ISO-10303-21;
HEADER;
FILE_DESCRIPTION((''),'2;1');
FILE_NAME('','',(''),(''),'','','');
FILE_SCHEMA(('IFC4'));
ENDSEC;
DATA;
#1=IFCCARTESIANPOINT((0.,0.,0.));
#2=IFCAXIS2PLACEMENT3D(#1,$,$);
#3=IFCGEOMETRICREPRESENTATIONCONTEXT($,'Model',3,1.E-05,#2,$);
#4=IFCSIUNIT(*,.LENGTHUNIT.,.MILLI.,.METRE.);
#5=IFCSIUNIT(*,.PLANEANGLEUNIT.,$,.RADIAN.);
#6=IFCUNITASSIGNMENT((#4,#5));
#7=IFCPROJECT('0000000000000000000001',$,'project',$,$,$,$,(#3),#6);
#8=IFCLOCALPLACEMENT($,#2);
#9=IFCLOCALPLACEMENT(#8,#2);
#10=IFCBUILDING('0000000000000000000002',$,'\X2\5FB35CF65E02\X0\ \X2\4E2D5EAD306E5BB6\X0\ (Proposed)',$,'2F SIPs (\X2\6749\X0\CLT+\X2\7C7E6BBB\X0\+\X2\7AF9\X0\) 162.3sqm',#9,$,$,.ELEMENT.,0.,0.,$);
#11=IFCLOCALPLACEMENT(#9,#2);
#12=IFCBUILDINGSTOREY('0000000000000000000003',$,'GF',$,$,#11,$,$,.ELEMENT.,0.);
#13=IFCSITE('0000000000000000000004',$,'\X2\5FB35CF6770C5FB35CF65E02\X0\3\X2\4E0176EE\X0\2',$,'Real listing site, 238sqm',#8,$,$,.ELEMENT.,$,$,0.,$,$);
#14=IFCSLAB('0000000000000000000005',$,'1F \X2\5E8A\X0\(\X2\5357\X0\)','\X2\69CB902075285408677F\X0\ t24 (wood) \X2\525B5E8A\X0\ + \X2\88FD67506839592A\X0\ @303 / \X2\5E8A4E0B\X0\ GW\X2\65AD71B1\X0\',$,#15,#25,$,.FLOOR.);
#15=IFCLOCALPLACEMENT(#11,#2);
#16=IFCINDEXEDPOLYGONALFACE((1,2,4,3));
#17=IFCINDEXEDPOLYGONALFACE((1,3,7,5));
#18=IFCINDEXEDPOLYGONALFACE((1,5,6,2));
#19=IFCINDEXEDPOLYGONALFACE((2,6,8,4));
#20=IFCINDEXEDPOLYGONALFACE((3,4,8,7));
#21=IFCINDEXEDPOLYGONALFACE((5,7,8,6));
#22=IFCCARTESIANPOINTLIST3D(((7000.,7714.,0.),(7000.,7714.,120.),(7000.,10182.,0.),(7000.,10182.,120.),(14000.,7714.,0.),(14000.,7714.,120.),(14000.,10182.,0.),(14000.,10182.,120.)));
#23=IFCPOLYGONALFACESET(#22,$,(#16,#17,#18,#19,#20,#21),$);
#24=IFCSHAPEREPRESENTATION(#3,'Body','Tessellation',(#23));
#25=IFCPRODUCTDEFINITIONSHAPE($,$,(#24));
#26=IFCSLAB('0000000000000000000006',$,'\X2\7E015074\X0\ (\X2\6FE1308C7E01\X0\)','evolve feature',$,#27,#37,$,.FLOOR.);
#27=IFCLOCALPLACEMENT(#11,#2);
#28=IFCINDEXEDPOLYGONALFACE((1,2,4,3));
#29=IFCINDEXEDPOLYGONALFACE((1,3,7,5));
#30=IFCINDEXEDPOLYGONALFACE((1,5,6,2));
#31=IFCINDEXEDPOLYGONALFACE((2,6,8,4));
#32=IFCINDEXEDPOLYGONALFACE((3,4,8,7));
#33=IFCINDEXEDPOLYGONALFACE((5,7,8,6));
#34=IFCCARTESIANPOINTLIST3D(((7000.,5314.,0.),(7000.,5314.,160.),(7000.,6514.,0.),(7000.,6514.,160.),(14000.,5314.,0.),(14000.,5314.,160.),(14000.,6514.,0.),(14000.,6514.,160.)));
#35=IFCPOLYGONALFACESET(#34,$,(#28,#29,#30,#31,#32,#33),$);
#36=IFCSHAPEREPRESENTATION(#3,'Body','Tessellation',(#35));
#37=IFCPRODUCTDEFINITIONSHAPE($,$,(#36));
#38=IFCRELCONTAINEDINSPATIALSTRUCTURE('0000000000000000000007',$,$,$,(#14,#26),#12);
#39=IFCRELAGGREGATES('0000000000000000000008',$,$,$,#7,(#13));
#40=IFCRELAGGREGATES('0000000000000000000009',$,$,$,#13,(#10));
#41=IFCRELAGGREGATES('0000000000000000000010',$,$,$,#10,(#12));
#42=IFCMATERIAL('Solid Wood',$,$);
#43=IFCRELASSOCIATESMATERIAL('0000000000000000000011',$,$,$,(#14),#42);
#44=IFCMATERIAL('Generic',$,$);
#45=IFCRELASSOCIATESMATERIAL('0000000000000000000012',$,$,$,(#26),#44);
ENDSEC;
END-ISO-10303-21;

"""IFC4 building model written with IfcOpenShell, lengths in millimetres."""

from ifc_helpers import new_model, si_unit, frame, frame_2d, origin, place, context, project, spatial, rectangle, extrude, material, element, save


model = new_model("IFC4")

# Units and contexts
model_context = context("Model", 3, precision=1e-05, world=origin())
ifc_project = project(units=[si_unit("LENGTHUNIT", "METRE", prefix="MILLI"), si_unit("PLANEANGLEUNIT", "RADIAN")], contexts=[model_context])

# Site, building, storey
site_placement = place(None, origin())
site = spatial("IfcSite", under=ifc_project, at=site_placement, Name="徳島県徳島市3丁目2", ObjectType="Real listing site, 238sqm", CompositionType="ELEMENT", RefElevation=0.0)
building_placement = place(site_placement, origin())
building = spatial("IfcBuilding", under=site, at=building_placement, Name="徳島市 中庭の家 (Proposed)", ObjectType="2F SIPs (杉CLT+籾殻+竹) 162.3sqm", CompositionType="ELEMENT", ElevationOfRefHeight=0.0, ElevationOfTerrain=0.0)
storey_placement = place(building_placement, origin())
storey = spatial("IfcBuildingStorey", under=building, at=storey_placement, Name="GF", CompositionType="ELEMENT", Elevation=0.0)

# Slabs
ifc_material_1 = material(Name="Solid Wood")
slab_1_placement = place(storey_placement, frame((3500.0, 3857.0, 0.0)))
element("IfcSlab", 1, at=slab_1_placement, inside=storey, material=ifc_material_1, Name="1F 床(南)", Description="構造用合板 t24 (wood) 剛床 + 製材根太 @303 / 床下 GW断熱", PredefinedType="FLOOR", context=model_context, shape_type="SweptSolid", body=[
    extrude(rectangle(XDim=7000.0, YDim=2468.0, at=frame_2d((3500.0, 1234.0))), frame((3500.0, 3857.0, 0.0)), (0.0, 0.0, 1.0), 120.0),
])
ifc_material_2 = material(Name="Generic")
slab_2_placement = place(storey_placement, frame((3500.0, 2657.0, 0.0)))
element("IfcSlab", 2, at=slab_2_placement, inside=storey, material=ifc_material_2, Name="縁側 (濡れ縁)", Description="evolve feature", PredefinedType="FLOOR", context=model_context, shape_type="SweptSolid", body=[
    extrude(rectangle(XDim=7000.0, YDim=1200.0, at=frame_2d((3500.0, 600.0))), frame((3500.0, 2657.0, 0.0)), (0.0, 0.0, 1.0), 160.0),
])

save(model, "model.ifc")
